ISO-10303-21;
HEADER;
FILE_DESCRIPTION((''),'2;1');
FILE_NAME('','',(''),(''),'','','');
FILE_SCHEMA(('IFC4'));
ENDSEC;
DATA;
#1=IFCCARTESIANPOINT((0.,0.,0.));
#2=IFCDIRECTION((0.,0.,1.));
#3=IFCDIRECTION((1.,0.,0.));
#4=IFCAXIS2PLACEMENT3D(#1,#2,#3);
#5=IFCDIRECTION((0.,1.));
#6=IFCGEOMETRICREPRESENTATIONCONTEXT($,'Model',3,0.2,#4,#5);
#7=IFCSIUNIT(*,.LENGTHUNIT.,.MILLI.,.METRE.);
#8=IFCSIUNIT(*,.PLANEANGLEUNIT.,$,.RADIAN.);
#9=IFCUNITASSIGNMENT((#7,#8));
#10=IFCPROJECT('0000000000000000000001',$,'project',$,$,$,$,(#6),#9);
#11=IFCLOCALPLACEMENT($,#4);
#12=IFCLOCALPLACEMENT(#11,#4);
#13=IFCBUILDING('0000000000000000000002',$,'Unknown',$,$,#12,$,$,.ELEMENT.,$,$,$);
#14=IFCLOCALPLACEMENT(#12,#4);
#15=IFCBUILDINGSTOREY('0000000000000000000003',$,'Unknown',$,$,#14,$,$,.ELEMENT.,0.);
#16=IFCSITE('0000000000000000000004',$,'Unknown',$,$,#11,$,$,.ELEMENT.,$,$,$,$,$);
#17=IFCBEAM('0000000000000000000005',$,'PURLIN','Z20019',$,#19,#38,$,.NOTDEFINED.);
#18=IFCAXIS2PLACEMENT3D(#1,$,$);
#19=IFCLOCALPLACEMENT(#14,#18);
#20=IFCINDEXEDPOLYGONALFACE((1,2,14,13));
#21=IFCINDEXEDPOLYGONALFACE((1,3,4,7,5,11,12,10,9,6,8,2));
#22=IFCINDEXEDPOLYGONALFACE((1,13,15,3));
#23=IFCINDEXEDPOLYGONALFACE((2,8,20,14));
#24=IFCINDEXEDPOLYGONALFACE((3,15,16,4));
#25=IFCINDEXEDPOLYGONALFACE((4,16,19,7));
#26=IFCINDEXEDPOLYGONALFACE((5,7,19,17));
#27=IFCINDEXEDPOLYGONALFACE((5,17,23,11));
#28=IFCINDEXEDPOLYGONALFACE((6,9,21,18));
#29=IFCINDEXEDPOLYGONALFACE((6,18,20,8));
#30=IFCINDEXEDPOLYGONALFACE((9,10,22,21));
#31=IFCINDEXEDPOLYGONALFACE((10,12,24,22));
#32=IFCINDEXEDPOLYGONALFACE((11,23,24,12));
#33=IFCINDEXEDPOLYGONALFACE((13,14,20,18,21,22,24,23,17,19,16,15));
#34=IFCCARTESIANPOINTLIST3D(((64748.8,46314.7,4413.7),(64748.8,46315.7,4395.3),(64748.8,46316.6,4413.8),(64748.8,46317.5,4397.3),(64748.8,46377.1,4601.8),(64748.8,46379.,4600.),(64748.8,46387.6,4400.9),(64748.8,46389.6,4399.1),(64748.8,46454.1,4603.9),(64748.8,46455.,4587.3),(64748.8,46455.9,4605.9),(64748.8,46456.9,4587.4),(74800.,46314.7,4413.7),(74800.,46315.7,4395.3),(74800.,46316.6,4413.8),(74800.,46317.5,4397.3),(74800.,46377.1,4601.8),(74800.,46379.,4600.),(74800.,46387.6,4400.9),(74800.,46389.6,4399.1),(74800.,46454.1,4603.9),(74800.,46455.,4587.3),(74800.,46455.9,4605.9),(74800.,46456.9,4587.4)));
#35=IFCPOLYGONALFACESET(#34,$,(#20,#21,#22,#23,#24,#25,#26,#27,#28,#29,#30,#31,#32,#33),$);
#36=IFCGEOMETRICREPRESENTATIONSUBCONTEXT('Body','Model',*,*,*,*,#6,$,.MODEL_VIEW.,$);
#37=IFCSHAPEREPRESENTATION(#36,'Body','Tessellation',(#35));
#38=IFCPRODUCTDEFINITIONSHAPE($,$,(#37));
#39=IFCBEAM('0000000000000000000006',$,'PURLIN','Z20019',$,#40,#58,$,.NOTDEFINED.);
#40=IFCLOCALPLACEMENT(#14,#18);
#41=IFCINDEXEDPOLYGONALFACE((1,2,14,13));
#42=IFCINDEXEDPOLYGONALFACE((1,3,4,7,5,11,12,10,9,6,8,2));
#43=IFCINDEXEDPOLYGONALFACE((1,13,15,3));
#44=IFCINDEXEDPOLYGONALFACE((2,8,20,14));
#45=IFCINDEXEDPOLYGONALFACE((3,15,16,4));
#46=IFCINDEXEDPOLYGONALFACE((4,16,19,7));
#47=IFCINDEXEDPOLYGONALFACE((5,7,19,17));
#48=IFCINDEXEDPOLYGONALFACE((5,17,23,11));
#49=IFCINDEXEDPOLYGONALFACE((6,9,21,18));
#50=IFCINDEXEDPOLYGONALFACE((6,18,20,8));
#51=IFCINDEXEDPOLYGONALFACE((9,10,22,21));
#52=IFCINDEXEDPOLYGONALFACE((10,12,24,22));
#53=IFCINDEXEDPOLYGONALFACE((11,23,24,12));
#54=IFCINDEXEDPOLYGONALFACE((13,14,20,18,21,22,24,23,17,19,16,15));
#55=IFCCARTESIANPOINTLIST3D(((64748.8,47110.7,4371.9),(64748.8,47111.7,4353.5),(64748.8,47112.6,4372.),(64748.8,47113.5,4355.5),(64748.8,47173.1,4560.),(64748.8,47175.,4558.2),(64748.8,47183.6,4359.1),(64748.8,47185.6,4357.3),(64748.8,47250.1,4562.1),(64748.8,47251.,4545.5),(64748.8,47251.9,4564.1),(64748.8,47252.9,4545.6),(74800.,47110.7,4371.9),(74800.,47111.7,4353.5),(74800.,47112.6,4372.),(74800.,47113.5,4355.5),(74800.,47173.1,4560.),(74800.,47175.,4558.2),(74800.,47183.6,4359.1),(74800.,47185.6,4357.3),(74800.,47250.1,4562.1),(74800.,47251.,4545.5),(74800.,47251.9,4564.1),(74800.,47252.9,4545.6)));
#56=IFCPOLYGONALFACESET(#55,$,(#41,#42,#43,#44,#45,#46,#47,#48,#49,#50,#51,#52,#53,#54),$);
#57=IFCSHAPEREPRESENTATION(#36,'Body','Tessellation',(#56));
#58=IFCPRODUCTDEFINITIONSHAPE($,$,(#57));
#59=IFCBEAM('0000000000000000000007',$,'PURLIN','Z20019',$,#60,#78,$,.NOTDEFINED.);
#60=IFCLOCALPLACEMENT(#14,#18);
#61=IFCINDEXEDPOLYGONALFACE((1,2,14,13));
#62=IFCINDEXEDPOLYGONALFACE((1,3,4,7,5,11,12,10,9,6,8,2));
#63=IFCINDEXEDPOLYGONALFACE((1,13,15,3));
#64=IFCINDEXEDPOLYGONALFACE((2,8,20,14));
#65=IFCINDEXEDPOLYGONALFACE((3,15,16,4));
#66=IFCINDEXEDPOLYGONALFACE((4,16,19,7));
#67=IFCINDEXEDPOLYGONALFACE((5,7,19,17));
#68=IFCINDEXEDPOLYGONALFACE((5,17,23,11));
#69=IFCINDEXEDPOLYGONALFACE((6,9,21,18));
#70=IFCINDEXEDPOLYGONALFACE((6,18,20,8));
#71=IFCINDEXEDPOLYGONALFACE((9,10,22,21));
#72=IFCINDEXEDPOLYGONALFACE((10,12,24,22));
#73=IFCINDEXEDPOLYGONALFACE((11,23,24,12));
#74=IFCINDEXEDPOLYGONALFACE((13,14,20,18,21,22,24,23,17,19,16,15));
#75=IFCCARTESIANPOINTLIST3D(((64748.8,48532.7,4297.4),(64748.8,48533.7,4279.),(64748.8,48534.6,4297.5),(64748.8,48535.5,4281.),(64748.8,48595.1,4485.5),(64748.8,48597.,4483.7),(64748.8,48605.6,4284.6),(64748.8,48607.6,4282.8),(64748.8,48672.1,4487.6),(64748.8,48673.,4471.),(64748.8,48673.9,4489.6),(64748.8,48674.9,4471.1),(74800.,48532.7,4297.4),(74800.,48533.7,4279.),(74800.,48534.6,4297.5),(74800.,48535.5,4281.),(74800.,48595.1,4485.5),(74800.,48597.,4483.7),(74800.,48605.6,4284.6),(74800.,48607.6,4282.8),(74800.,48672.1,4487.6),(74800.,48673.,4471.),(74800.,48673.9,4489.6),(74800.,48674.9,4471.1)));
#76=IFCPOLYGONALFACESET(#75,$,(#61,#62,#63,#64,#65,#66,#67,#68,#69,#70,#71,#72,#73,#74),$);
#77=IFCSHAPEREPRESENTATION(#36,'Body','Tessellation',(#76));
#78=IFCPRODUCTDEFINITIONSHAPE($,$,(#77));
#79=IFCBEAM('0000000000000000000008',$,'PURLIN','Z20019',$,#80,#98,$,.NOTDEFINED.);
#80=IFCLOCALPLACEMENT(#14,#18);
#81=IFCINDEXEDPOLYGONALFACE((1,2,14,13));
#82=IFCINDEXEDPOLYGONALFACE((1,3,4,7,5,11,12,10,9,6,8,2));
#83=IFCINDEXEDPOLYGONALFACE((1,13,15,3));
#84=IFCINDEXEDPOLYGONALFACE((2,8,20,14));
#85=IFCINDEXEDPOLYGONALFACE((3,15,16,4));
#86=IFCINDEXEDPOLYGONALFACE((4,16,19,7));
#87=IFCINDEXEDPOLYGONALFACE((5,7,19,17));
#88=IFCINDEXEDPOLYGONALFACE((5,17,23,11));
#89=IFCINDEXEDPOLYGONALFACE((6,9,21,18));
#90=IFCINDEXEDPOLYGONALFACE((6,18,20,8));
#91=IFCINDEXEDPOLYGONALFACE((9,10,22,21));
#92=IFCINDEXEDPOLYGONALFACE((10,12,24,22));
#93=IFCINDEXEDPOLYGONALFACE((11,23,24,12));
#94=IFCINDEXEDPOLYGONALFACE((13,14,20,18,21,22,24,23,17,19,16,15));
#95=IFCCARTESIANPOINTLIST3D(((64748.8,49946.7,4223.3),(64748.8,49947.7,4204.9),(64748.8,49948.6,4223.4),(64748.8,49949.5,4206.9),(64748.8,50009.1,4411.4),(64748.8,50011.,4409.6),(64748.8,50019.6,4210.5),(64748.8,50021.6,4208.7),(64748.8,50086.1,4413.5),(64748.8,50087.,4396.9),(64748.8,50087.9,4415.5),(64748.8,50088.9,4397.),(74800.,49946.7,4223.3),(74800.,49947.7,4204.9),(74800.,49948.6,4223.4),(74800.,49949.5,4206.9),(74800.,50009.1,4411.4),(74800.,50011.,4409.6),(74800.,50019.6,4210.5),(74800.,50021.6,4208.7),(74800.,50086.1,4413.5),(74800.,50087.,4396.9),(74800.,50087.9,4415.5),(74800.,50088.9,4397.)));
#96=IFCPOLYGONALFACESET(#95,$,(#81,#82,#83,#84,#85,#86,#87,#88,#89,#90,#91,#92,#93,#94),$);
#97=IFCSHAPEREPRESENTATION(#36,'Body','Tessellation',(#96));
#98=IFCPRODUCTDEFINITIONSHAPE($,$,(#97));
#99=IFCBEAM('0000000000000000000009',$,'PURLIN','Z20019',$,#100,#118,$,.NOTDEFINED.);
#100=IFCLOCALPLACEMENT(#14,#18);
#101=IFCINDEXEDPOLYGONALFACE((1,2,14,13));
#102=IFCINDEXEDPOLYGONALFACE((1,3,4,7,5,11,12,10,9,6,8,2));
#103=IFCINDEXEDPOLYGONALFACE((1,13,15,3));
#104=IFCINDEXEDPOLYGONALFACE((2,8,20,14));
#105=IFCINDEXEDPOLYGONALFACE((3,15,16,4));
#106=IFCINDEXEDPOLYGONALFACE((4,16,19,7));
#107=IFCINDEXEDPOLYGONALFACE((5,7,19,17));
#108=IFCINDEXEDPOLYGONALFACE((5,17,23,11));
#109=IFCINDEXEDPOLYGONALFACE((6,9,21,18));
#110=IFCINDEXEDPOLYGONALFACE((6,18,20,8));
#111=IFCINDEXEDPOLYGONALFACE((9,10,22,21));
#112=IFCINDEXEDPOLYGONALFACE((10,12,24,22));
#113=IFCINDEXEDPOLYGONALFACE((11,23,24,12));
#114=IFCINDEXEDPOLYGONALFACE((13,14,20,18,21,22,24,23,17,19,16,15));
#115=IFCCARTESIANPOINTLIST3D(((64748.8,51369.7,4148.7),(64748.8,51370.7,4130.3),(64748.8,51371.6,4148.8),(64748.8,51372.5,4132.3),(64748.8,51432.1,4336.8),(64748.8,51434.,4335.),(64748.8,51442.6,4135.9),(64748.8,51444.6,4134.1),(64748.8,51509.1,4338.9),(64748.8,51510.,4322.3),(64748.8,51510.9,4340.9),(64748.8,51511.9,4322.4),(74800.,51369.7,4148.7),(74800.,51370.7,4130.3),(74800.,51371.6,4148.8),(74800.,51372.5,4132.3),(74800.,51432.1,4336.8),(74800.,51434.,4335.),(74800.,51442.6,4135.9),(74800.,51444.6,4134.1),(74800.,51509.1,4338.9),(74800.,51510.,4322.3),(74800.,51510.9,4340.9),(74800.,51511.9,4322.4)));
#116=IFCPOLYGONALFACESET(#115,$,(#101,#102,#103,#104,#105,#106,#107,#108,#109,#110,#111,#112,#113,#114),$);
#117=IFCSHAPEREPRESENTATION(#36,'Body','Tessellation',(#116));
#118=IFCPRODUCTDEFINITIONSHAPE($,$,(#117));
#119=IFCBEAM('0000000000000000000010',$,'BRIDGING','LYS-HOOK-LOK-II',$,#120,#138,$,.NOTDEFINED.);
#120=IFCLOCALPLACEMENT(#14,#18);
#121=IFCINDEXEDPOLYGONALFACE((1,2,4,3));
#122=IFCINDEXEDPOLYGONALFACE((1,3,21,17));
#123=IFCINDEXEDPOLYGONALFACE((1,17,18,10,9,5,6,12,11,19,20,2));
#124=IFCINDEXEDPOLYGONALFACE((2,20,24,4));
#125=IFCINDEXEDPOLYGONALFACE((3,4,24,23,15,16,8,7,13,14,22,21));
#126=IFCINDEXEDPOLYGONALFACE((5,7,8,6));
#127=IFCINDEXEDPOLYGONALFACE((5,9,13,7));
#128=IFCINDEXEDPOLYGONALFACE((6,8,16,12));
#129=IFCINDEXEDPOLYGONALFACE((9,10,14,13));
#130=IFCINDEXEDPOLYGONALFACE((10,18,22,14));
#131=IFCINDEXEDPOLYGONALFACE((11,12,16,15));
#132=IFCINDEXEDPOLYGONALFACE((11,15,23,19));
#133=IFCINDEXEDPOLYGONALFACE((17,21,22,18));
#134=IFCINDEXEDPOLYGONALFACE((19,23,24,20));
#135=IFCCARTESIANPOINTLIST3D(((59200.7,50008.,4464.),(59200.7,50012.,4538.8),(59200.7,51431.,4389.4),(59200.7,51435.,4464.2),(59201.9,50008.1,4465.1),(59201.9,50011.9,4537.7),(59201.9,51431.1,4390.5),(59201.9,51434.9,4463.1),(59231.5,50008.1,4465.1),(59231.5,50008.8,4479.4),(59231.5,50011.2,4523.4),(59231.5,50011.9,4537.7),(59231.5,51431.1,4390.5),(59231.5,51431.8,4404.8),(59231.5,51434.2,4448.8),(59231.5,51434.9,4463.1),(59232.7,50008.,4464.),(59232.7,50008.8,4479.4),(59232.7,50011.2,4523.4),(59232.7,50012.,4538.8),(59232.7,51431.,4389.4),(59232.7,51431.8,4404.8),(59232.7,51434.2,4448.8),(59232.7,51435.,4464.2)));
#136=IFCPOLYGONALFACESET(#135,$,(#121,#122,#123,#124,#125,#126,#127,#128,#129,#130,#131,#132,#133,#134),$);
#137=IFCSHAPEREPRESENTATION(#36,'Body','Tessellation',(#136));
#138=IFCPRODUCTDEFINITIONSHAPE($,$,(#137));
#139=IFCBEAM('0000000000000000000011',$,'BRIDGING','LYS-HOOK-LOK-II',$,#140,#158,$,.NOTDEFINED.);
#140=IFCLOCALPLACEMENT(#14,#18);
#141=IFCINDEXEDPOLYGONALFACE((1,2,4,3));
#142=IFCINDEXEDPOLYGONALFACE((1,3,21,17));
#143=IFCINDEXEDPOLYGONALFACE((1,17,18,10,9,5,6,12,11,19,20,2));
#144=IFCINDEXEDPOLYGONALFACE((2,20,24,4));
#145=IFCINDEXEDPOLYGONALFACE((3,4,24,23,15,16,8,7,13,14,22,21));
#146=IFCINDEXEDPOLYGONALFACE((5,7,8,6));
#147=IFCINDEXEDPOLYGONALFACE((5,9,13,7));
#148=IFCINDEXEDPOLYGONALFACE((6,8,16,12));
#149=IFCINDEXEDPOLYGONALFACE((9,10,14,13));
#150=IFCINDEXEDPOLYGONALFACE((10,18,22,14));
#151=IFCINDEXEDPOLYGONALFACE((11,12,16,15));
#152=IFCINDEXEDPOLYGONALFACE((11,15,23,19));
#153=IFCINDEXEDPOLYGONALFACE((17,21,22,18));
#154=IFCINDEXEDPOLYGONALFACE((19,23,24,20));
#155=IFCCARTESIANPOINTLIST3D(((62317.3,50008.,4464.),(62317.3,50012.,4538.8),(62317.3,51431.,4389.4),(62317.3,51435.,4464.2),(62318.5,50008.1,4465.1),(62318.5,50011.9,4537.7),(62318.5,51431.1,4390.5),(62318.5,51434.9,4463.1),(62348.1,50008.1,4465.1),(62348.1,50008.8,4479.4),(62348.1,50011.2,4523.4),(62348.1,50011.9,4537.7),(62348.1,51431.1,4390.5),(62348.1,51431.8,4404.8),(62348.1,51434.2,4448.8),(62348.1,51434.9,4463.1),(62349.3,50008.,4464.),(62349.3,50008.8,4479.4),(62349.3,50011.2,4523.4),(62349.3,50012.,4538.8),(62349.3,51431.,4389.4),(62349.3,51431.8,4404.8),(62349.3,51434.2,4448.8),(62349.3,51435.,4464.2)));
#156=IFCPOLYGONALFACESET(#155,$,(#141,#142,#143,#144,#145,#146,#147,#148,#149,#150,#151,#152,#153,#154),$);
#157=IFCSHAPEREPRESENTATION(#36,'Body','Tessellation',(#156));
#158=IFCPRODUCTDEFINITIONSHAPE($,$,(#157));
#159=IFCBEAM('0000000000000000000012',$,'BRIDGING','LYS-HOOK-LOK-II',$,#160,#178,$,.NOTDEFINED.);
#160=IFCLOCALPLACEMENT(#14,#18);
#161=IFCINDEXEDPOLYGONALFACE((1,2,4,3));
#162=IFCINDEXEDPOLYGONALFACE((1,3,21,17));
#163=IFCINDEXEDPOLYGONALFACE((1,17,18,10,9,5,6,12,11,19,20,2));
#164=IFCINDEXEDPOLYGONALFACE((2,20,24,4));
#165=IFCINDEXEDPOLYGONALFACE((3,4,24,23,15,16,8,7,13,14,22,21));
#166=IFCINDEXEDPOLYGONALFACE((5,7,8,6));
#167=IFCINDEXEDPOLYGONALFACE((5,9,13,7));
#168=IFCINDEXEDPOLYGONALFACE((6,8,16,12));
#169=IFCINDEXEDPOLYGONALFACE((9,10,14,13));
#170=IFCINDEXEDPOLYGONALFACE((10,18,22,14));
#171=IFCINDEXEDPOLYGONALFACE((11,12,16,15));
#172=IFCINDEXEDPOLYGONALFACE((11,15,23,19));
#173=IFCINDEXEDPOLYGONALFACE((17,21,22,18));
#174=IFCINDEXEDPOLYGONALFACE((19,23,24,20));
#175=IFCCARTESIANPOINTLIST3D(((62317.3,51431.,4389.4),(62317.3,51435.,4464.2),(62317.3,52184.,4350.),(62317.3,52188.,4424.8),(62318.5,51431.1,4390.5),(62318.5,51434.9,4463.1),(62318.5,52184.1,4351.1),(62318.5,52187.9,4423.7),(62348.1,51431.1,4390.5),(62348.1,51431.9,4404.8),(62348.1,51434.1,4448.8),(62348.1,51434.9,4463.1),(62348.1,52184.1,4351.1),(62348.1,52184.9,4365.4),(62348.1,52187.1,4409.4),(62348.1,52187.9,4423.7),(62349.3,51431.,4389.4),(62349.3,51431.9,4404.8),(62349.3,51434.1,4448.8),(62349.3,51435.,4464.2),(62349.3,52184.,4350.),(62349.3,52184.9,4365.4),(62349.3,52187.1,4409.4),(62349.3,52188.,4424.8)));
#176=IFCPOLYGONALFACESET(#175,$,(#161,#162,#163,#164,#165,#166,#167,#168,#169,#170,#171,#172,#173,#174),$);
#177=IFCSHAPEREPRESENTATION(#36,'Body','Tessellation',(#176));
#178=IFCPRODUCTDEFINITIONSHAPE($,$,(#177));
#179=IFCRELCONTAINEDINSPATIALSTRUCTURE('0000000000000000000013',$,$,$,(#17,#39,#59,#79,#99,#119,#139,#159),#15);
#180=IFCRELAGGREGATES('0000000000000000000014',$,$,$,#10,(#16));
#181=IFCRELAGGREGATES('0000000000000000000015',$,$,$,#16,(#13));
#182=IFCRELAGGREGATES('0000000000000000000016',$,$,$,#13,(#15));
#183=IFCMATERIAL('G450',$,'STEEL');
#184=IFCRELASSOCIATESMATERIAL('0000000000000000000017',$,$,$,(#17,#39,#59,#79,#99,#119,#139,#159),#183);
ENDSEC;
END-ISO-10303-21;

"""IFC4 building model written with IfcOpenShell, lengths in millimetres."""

from ifc_helpers import new_model, si_unit, direction, frame, origin_with_axes, place, context, subcontext, project, spatial, line, indexed_curve, outline, extrude, material, element, save


model = new_model("IFC4")

# Units and contexts
model_context = context("Model", 3, precision=0.2, world=origin_with_axes(), true_north=direction((0.0, 1.0)))
body_context = subcontext(model_context, "Body", "Model", "MODEL_VIEW")
ifc_project = project(units=[si_unit("LENGTHUNIT", "METRE", prefix="MILLI"), si_unit("PLANEANGLEUNIT", "RADIAN")], contexts=[model_context])

# Site, building, storey
site_placement = place(None, origin_with_axes())
site = spatial("IfcSite", under=ifc_project, at=site_placement, Name="Unknown", CompositionType="ELEMENT")
building_placement = place(site_placement, origin_with_axes())
building = spatial("IfcBuilding", under=site, at=building_placement, Name="Unknown", CompositionType="ELEMENT")
storey_placement = place(building_placement, origin_with_axes())
storey = spatial("IfcBuildingStorey", under=building, at=storey_placement, Name="Unknown", CompositionType="ELEMENT", Elevation=0.0)

# Shared definitions
ifc_material = material(Name="G450", Category="STEEL")

# Beams
for number, where, z_axis, x_axis, name in (
    (1, (64748.8, 46383.3, 4500.4), (0.0, -0.99863, -0.052336), (1.0, 0.0, 0.0), "PURLIN"),
    (2, (64748.8, 47179.3, 4458.6), (0.0, -0.99863, -0.052336), (1.0, 0.0, 0.0), "PURLIN"),
    (3, (64748.8, 48601.3, 4384.1), (0.0, -0.99863, -0.052336), (1.0, 0.0, 0.0), "PURLIN"),
    (4, (64748.8, 50015.3, 4310.0), (0.0, -0.99863, -0.052336), (1.0, 0.0, 0.0), "PURLIN"),
    (5, (64748.8, 51438.3, 4235.4), (0.0, -0.99863, -0.052336), (1.0, 0.0, 0.0), "PURLIN"),
):
    element("IfcBeam", number, at=place(storey_placement, frame(where, z_axis=z_axis, x_axis=x_axis)), inside=storey, material=ifc_material, Name=name, Description="Z20019", PredefinedType="NOTDEFINED", context=body_context, shape_type="SolidModel", body=[
        extrude(outline(indexed_curve([(73.0, -101.5), (73.0, -83.0), (71.2, -83.0), (71.2, -99.6), (0.9, -99.6), (0.9, 101.5), (-78.0, 101.5), (-78.0, 83.0), (-76.2, 83.0), (-76.2, 99.6), (-0.9, 99.6), (-0.9, -101.5)], segments=[line(1, 2, 3, 4, 5, 6, 7, 8, 9, 10, 11, 12, 1)])), frame((0.0, 0.0, 0.0), z_axis=(-1.0, 0.0, 0.0), x_axis=(0.0, 0.0, 1.0)), (0.0, 0.0, -1.0), 10051.2),
    ])
for number, where, z_axis, x_axis, name in (
    (6, (59216.7, 50010.0, 4501.4), (1.0, 0.0, 0.0), (0.0, 0.998629, -0.052353), "BRIDGING"),
    (7, (62333.3, 50010.0, 4501.4), (1.0, 0.0, 0.0), (0.0, 0.998629, -0.052353), "BRIDGING"),
):
    element("IfcBeam", number, at=place(storey_placement, frame(where, z_axis=z_axis, x_axis=x_axis)), inside=storey, material=ifc_material, Name=name, Description="LYS-HOOK-LOK-II", PredefinedType="NOTDEFINED", context=body_context, shape_type="SolidModel", body=[
        extrude(outline(indexed_curve([(16.0, -37.5), (16.0, -22.0), (14.8, -22.0), (14.8, -36.3), (-14.8, -36.3), (-14.8, 36.3), (14.8, 36.3), (14.8, 22.0), (16.0, 22.0), (16.0, 37.5), (-16.0, 37.5), (-16.0, -37.5)], segments=[line(1, 2, 3, 4, 5, 6, 7, 8, 9, 10, 11, 12, 1)])), frame((0.0, 0.0, 0.0), z_axis=(-1.0, 0.0, 0.0), x_axis=(0.0, 0.0, 1.0)), (0.0, 0.0, -1.0), 1425.0),
    ])
beam_placement = place(storey_placement, frame((62333.3, 51433.0, 4426.8), z_axis=(1.0, 0.0, 0.0), x_axis=(0.0, 0.998634, -0.052253)))
element("IfcBeam", 8, at=beam_placement, inside=storey, material=ifc_material, Name="BRIDGING", Description="LYS-HOOK-LOK-II", PredefinedType="NOTDEFINED", context=body_context, shape_type="SolidModel", body=[
    extrude(outline(indexed_curve([(16.0, -37.5), (16.0, -22.0), (14.8, -22.0), (14.8, -36.3), (-14.8, -36.3), (-14.8, 36.3), (14.8, 36.3), (14.8, 22.0), (16.0, 22.0), (16.0, 37.5), (-16.0, 37.5), (-16.0, -37.5)], segments=[line(1, 2, 3, 4, 5, 6, 7, 8, 9, 10, 11, 12, 1)])), frame((0.0, 0.0, 0.0), z_axis=(-1.0, 0.0, 0.0), x_axis=(0.0, 0.0, 1.0)), (0.0, 0.0, -1.0), 754.0),
])

save(model, "model.ifc")
